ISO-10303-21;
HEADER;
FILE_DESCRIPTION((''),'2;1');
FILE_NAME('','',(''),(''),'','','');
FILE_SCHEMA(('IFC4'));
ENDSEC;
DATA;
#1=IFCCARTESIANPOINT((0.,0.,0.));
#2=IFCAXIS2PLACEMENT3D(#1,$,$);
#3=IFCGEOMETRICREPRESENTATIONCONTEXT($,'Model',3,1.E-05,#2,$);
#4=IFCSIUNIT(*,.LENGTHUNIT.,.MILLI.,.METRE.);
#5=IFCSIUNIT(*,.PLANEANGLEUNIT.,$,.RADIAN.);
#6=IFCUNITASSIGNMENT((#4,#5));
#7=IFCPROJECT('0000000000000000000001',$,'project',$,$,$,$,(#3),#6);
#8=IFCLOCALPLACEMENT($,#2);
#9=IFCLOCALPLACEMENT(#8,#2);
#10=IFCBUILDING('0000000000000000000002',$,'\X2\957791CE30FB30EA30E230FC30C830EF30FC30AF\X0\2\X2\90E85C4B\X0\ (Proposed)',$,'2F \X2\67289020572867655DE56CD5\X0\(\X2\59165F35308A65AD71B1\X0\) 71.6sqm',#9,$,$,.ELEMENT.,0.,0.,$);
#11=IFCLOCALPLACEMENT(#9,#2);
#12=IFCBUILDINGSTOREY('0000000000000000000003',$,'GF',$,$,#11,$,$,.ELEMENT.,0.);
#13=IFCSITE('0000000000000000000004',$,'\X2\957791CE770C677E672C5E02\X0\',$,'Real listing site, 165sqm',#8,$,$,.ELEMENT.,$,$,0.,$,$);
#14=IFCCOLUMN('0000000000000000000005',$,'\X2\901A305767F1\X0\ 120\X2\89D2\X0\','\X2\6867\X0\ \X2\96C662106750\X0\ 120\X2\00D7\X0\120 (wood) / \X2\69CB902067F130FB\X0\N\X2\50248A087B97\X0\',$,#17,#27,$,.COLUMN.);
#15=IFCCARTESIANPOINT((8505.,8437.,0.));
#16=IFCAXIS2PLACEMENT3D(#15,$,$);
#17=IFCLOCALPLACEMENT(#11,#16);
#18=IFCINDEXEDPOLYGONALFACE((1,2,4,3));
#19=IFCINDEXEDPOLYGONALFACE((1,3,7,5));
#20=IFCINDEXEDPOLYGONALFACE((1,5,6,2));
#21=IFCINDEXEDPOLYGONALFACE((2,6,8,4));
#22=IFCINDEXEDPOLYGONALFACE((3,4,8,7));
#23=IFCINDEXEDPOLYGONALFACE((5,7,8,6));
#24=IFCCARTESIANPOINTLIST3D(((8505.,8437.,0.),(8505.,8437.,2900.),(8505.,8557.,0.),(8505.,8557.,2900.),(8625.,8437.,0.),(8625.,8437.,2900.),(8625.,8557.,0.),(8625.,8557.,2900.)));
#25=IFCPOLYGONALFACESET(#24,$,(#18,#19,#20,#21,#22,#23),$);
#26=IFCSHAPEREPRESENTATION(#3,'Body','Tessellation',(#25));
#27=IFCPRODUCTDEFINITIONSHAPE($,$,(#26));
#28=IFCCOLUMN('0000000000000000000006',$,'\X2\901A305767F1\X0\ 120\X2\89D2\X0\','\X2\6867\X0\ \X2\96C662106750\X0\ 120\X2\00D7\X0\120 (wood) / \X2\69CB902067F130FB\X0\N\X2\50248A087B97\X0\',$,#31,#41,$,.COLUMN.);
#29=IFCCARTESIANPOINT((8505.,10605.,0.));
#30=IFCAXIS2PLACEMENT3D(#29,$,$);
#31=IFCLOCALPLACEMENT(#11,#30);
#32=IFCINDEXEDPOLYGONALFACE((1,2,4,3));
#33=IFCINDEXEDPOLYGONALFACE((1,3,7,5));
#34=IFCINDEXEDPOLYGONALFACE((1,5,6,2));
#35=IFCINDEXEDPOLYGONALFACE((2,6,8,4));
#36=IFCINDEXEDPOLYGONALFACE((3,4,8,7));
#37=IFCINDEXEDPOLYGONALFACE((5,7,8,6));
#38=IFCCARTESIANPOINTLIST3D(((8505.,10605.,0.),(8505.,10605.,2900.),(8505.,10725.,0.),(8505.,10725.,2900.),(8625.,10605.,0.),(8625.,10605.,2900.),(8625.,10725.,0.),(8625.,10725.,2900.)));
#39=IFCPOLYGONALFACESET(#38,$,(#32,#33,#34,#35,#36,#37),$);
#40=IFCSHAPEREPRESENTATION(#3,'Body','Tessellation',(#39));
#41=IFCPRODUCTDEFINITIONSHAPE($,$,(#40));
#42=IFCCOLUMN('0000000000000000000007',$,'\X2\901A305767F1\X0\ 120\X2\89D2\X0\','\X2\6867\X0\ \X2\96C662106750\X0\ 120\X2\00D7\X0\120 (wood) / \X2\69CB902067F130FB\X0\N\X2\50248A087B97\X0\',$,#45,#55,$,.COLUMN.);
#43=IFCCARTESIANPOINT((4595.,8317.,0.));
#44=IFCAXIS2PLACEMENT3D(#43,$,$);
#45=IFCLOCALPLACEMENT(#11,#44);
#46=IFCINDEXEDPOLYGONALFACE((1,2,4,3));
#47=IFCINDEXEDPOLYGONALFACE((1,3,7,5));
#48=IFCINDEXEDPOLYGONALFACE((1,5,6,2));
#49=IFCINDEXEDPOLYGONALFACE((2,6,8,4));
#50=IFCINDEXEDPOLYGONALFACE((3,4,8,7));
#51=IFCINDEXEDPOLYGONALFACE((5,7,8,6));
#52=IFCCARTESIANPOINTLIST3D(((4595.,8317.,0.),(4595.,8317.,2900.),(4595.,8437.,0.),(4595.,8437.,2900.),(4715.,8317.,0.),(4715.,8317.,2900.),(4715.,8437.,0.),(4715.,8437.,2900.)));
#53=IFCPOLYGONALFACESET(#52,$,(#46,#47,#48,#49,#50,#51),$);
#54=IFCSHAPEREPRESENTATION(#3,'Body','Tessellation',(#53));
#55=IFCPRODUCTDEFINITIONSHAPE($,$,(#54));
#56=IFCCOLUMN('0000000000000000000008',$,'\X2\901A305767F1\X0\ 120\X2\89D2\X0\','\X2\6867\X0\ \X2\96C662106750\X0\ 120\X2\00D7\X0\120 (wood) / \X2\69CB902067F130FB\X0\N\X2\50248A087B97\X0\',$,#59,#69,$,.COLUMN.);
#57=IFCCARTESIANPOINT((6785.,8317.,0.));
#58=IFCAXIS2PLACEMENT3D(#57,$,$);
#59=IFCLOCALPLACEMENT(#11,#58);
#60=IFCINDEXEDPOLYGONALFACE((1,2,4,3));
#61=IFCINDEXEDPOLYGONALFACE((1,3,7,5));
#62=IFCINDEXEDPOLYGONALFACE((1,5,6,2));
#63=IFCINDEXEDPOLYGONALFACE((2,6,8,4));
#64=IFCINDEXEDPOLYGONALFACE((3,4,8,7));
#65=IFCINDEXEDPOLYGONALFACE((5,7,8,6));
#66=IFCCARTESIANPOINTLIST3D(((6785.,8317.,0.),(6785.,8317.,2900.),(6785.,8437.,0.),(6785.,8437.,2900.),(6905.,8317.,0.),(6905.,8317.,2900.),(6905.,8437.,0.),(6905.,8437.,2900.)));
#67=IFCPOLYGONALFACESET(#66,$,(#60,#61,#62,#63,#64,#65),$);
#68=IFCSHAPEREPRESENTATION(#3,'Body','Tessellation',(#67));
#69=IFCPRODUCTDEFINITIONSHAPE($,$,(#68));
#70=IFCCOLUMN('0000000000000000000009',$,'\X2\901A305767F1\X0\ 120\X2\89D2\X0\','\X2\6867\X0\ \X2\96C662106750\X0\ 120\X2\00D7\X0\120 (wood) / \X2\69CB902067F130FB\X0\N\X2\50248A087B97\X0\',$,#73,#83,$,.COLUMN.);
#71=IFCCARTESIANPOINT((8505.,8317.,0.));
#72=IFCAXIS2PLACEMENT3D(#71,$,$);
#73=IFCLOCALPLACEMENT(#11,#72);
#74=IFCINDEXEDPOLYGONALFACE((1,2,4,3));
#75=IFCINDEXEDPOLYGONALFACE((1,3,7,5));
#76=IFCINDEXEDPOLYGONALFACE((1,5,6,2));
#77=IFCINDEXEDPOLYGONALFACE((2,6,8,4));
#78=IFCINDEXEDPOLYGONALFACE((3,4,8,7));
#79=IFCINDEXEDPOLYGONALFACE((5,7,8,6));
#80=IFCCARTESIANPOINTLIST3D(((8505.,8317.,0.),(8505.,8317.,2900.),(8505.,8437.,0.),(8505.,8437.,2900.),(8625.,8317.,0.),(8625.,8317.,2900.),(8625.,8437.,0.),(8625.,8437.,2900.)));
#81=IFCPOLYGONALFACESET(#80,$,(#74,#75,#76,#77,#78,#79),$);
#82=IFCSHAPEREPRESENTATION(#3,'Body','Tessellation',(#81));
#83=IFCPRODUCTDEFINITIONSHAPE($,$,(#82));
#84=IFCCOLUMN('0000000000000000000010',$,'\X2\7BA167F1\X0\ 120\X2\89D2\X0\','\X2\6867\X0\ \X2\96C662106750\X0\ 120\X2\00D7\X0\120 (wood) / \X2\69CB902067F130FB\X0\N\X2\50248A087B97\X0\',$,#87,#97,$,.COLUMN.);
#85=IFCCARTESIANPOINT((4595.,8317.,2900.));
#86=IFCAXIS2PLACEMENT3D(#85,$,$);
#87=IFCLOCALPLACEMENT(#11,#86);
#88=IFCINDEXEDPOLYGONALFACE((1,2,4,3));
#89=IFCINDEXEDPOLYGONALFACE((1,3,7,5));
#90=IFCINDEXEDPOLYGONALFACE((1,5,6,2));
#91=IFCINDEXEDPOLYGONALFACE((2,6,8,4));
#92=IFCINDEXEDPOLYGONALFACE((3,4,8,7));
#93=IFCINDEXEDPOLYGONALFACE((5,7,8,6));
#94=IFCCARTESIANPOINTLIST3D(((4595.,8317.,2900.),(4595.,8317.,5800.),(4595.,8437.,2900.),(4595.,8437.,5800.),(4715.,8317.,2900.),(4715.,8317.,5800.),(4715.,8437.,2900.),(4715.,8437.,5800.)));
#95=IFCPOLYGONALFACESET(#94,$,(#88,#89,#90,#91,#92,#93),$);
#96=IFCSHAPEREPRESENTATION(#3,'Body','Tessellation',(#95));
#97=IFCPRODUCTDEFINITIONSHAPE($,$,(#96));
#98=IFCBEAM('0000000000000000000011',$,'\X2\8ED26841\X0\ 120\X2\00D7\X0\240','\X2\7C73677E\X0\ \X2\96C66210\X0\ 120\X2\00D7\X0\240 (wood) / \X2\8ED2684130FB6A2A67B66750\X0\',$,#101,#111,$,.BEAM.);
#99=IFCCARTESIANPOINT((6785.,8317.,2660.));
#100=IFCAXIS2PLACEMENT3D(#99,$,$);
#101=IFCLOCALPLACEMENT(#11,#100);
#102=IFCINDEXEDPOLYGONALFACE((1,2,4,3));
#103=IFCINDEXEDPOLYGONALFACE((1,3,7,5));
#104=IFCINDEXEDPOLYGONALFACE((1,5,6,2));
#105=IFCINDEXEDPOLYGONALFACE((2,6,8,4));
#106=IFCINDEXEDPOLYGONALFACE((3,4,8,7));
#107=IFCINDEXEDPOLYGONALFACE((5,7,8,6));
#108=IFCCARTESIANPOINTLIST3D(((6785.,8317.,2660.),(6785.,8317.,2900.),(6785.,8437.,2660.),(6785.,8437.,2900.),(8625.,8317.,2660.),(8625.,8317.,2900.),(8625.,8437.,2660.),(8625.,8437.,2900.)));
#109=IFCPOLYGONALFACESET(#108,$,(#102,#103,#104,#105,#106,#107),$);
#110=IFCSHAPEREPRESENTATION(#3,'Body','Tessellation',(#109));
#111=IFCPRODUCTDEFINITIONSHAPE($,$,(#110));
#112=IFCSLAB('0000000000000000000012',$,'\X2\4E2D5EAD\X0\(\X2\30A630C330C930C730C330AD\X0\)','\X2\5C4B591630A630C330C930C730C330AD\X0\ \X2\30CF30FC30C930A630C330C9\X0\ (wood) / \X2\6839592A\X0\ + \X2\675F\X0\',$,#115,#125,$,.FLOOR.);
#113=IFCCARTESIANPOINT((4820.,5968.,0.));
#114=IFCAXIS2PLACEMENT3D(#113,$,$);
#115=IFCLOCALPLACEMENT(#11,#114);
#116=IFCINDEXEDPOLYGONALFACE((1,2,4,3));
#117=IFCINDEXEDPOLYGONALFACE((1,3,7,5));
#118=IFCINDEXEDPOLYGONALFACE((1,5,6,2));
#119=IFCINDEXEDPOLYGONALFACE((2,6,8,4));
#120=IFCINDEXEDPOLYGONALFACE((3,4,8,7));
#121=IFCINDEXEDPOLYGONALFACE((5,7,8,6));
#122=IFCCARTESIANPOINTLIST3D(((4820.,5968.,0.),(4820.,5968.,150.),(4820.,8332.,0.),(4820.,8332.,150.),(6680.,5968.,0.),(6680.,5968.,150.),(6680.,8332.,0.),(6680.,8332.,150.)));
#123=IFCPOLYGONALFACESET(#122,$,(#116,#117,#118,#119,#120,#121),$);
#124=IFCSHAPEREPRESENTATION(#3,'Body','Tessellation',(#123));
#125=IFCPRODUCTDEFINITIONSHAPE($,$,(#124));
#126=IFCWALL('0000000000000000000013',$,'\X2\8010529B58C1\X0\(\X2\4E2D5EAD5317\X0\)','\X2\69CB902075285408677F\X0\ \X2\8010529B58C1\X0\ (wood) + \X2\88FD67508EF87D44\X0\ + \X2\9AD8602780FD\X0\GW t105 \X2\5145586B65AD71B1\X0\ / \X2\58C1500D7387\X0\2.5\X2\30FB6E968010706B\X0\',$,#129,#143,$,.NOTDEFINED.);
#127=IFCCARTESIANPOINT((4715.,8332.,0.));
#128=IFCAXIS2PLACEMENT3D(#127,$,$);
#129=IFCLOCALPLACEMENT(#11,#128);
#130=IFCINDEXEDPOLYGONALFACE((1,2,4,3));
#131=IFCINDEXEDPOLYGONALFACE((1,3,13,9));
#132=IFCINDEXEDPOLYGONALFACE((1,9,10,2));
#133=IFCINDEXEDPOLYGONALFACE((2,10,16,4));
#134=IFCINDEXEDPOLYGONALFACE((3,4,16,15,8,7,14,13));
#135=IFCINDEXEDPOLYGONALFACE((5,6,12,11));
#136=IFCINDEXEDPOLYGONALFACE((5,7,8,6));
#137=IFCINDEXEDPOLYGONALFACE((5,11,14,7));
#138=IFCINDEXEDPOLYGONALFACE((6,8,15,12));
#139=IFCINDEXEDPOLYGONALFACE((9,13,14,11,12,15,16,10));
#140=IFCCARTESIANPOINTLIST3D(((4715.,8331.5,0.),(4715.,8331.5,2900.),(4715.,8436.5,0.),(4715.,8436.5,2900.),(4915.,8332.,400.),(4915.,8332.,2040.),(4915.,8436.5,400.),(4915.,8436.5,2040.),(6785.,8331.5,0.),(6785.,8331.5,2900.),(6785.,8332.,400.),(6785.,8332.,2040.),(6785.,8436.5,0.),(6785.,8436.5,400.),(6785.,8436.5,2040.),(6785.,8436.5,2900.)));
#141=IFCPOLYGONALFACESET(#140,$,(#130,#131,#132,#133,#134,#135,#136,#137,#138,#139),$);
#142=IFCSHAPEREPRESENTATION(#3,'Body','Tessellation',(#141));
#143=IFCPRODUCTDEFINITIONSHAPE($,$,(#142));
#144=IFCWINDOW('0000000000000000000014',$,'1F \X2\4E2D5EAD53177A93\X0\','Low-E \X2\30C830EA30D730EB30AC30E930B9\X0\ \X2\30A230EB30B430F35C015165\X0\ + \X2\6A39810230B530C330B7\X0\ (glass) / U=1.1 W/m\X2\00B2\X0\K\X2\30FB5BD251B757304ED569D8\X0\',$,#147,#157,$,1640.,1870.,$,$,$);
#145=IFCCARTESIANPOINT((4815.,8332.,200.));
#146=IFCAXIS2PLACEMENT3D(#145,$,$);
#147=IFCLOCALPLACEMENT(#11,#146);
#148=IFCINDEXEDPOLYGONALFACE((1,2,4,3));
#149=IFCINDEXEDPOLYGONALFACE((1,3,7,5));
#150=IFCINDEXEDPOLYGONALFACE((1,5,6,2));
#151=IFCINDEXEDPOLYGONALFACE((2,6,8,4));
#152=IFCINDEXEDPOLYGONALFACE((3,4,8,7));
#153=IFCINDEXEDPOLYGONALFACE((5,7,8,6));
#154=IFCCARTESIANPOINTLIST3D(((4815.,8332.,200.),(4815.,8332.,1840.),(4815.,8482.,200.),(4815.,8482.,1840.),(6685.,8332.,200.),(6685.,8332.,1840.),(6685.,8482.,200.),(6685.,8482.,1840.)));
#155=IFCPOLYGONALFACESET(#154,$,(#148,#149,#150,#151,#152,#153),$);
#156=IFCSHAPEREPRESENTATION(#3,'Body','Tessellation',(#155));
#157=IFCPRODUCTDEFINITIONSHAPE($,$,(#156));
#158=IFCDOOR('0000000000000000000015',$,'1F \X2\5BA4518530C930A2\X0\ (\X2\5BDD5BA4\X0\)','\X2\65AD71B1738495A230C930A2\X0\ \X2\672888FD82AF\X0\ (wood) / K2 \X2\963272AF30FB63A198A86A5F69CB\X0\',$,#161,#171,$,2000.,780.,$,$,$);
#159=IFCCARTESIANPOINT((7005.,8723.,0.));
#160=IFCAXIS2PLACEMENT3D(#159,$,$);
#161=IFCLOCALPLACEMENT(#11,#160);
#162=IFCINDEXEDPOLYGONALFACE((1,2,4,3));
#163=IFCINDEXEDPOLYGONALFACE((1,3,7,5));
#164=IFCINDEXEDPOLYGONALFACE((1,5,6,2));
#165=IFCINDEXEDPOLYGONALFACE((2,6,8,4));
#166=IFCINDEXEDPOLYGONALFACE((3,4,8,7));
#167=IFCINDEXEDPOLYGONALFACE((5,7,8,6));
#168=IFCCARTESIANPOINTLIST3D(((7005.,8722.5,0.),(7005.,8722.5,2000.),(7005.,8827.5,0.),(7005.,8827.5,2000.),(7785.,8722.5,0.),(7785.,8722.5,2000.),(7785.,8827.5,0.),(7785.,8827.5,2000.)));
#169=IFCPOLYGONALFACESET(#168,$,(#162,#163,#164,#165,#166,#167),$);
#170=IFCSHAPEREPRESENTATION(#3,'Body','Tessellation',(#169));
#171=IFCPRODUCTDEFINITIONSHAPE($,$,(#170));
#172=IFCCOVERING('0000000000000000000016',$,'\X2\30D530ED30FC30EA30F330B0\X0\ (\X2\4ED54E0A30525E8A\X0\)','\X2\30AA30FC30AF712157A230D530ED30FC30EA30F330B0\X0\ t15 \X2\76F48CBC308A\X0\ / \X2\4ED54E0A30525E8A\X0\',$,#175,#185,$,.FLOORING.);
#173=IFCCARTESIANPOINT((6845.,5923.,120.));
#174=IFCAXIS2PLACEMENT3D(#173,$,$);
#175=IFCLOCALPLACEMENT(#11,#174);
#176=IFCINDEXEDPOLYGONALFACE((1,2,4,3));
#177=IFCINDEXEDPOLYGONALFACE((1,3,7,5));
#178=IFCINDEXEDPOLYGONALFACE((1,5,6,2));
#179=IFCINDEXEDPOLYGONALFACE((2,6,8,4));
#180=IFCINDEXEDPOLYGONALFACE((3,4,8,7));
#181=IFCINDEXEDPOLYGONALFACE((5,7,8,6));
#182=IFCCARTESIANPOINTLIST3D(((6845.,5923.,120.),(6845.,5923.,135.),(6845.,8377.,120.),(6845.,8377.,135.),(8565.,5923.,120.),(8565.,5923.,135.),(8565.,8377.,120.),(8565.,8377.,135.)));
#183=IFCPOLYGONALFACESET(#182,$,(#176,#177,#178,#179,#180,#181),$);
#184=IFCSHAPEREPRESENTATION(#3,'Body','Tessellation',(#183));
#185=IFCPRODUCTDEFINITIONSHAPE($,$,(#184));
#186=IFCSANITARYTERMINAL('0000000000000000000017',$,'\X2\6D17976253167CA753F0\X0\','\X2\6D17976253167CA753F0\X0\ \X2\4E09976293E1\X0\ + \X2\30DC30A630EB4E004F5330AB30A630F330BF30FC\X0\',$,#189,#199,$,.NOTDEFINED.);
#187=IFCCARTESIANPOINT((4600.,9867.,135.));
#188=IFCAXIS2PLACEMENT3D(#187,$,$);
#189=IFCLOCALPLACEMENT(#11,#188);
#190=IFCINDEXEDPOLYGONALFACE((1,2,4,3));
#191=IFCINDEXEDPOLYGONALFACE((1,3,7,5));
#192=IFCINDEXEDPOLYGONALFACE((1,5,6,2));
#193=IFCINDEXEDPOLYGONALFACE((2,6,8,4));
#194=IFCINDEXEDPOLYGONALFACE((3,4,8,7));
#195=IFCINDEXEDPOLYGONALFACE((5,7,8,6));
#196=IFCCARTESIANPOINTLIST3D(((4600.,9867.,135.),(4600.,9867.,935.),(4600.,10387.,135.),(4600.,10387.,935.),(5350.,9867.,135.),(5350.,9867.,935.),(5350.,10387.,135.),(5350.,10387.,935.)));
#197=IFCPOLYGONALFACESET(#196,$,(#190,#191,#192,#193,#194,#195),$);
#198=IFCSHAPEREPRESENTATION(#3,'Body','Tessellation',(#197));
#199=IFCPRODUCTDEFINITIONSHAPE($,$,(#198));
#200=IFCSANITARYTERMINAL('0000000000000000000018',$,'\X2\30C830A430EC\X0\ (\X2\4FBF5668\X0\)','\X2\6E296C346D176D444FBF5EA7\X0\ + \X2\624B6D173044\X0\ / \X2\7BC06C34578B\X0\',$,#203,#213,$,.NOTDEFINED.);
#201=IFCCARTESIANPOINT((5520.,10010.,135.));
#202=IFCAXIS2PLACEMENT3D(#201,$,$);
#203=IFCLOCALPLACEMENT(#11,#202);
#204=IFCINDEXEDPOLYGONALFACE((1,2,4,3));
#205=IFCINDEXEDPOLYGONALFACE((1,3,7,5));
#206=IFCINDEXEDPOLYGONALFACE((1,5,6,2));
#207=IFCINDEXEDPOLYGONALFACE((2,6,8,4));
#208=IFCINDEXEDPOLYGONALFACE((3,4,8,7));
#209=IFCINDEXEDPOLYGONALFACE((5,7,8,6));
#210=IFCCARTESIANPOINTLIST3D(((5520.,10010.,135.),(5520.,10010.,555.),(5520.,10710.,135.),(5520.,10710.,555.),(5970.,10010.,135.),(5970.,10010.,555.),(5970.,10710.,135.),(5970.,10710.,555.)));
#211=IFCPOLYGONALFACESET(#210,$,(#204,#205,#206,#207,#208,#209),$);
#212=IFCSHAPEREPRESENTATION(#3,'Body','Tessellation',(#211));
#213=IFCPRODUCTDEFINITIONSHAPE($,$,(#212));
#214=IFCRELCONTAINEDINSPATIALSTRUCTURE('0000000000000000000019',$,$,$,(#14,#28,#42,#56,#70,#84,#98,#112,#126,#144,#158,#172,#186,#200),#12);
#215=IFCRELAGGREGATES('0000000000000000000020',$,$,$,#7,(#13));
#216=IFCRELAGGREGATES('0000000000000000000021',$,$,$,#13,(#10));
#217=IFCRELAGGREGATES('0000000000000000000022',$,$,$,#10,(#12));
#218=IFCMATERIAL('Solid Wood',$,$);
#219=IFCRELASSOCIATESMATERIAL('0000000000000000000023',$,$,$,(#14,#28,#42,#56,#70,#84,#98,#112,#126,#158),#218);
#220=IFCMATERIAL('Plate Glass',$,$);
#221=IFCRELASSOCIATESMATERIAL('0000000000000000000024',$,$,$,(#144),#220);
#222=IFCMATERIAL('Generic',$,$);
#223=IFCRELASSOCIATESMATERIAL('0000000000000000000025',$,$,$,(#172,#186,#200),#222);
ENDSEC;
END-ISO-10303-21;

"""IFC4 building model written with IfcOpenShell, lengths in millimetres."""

from ifc_helpers import new_model, si_unit, frame, frame_2d, origin, place, context, project, spatial, rectangle, extrude, material, element, fill, save


model = new_model("IFC4")

# Units and contexts
model_context = context("Model", 3, precision=1e-05, world=origin())
ifc_project = project(units=[si_unit("LENGTHUNIT", "METRE", prefix="MILLI"), si_unit("PLANEANGLEUNIT", "RADIAN")], contexts=[model_context])

# Site, building, storey
site_placement = place(None, origin())
site = spatial("IfcSite", under=ifc_project, at=site_placement, Name="長野県松本市", ObjectType="Real listing site, 165sqm", CompositionType="ELEMENT", RefElevation=0.0)
building_placement = place(site_placement, origin())
building = spatial("IfcBuilding", under=site, at=building_placement, Name="長野・リモートワーク2部屋 (Proposed)", ObjectType="2F 木造在来工法(外張り断熱) 71.6sqm", CompositionType="ELEMENT", ElevationOfRefHeight=0.0, ElevationOfTerrain=0.0)
storey_placement = place(building_placement, origin())
storey = spatial("IfcBuildingStorey", under=building, at=storey_placement, Name="GF", CompositionType="ELEMENT", Elevation=0.0)

# Columns
ifc_material_1 = material(Name="Solid Wood")
column_1_placement = place(storey_placement, frame((8505.0, 8437.0, 0.0)))
element("IfcColumn", 1, at=column_1_placement, inside=storey, material=ifc_material_1, Name="通し柱 120角", Description="桧 集成材 120×120 (wood) / 構造柱・N値計算", PredefinedType="COLUMN", context=model_context, shape_type="SweptSolid", body=[
    extrude(rectangle(XDim=120.0, YDim=120.0, at=frame_2d((60.0, 60.0))), frame((8505.0, 8437.0, 0.0)), (0.0, 0.0, 1.0), 2900.0),
])
column_2_placement = place(storey_placement, frame((8505.0, 10605.0, 0.0)))
element("IfcColumn", 2, at=column_2_placement, inside=storey, material=ifc_material_1, Name="通し柱 120角", Description="桧 集成材 120×120 (wood) / 構造柱・N値計算", PredefinedType="COLUMN", context=model_context, shape_type="SweptSolid", body=[
    extrude(rectangle(XDim=120.0, YDim=120.0, at=frame_2d((60.0, 60.0))), frame((8505.0, 10605.0, 0.0)), (0.0, 0.0, 1.0), 2900.0),
])
column_3_placement = place(storey_placement, frame((4595.0, 8317.0, 0.0)))
element("IfcColumn", 3, at=column_3_placement, inside=storey, material=ifc_material_1, Name="通し柱 120角", Description="桧 集成材 120×120 (wood) / 構造柱・N値計算", PredefinedType="COLUMN", context=model_context, shape_type="SweptSolid", body=[
    extrude(rectangle(XDim=120.0, YDim=120.0, at=frame_2d((60.0, 60.0))), frame((4595.0, 8317.0, 0.0)), (0.0, 0.0, 1.0), 2900.0),
])
column_4_placement = place(storey_placement, frame((6785.0, 8317.0, 0.0)))
element("IfcColumn", 4, at=column_4_placement, inside=storey, material=ifc_material_1, Name="通し柱 120角", Description="桧 集成材 120×120 (wood) / 構造柱・N値計算", PredefinedType="COLUMN", context=model_context, shape_type="SweptSolid", body=[
    extrude(rectangle(XDim=120.0, YDim=120.0, at=frame_2d((60.0, 60.0))), frame((6785.0, 8317.0, 0.0)), (0.0, 0.0, 1.0), 2900.0),
])
column_5_placement = place(storey_placement, frame((8505.0, 8317.0, 0.0)))
element("IfcColumn", 5, at=column_5_placement, inside=storey, material=ifc_material_1, Name="通し柱 120角", Description="桧 集成材 120×120 (wood) / 構造柱・N値計算", PredefinedType="COLUMN", context=model_context, shape_type="SweptSolid", body=[
    extrude(rectangle(XDim=120.0, YDim=120.0, at=frame_2d((60.0, 60.0))), frame((8505.0, 8317.0, 0.0)), (0.0, 0.0, 1.0), 2900.0),
])
column_6_placement = place(storey_placement, frame((4595.0, 8317.0, 2900.0)))
element("IfcColumn", 6, at=column_6_placement, inside=storey, material=ifc_material_1, Name="管柱 120角", Description="桧 集成材 120×120 (wood) / 構造柱・N値計算", PredefinedType="COLUMN", context=model_context, shape_type="SweptSolid", body=[
    extrude(rectangle(XDim=120.0, YDim=120.0, at=frame_2d((60.0, 60.0))), frame((4595.0, 8317.0, 2900.0)), (0.0, 0.0, 1.0), 2900.0),
])

# Beam
beam_1_placement = place(storey_placement, frame((6785.0, 8317.0, 2660.0)))
element("IfcBeam", 7, at=beam_1_placement, inside=storey, material=ifc_material_1, Name="軒桁 120×240", Description="米松 集成 120×240 (wood) / 軒桁・横架材", PredefinedType="BEAM", context=model_context, shape_type="SweptSolid", body=[
    extrude(rectangle(XDim=1840.0, YDim=120.0, at=frame_2d((920.0, 60.0))), frame((6785.0, 8317.0, 2660.0)), (0.0, 0.0, 1.0), 240.0),
])

# Slab
slab_placement = place(storey_placement, frame((4820.0, 5968.0, 0.0)))
element("IfcSlab", 8, at=slab_placement, inside=storey, material=ifc_material_1, Name="中庭(ウッドデッキ)", Description="屋外ウッドデッキ ハードウッド (wood) / 根太 + 束", PredefinedType="FLOOR", context=model_context, shape_type="SweptSolid", body=[
    extrude(rectangle(XDim=1860.0, YDim=2364.0, at=frame_2d((930.0, 1182.0))), frame((4820.0, 5968.0, 0.0)), (0.0, 0.0, 1.0), 150.0),
])

# Wall, opening, window
wall_1_placement = place(storey_placement, frame((4715.0, 8332.0, 0.0)))
wall_1 = element("IfcWall", 9, at=wall_1_placement, inside=storey, material=ifc_material_1, Name="耐力壁(中庭北)", Description="構造用合板 耐力壁 (wood) + 製材軸組 + 高性能GW t105 充填断熱 / 壁倍率2.5・準耐火", PredefinedType="NOTDEFINED", context=model_context, shape_type="SweptSolid", body=[
    extrude(rectangle(XDim=2070.0, YDim=105.0, at=frame_2d((1035.0, 52.0))), frame((4715.0, 8332.0, 0.0)), (0.0, 0.0, 1.0), 2900.0),
])
opening_placement = place(storey_placement, frame((4815.0, 8332.0, 200.0)))
opening = element("IfcOpeningElement", 10, at=opening_placement, cuts=wall_1, PredefinedType="NOTDEFINED", context=model_context, shape_type="SweptSolid", body=[
    extrude(rectangle(XDim=1870.0, YDim=150.0, at=frame_2d((935.0, 75.0))), frame((4815.0, 8332.0, 200.0)), (0.0, 0.0, 1.0), 1640.0),
])
ifc_material_2 = material(Name="Plate Glass")
window_placement = place(storey_placement, frame((4815.0, 8332.0, 200.0)))
window = element("IfcWindow", 11, at=window_placement, inside=storey, material=ifc_material_2, Name="1F 中庭北窓", Description="Low-E トリプルガラス アルゴン封入 + 樹脂サッシ (glass) / U=1.1 W/m²K・寒冷地仕様", OverallHeight=1640.0, OverallWidth=1870.0, context=model_context, shape_type="SweptSolid", body=[
    extrude(rectangle(XDim=1870.0, YDim=150.0, at=frame_2d((935.0, 75.0))), frame((4815.0, 8332.0, 200.0)), (0.0, 0.0, 1.0), 1640.0),
])
fill(opening, window)

# Door
door_placement = place(storey_placement, frame((7005.0, 8723.0, 0.0)))
element("IfcDoor", 12, at=door_placement, inside=storey, material=ifc_material_1, Name="1F 室内ドア (寝室)", Description="断熱玄関ドア 木製芯 (wood) / K2 防犯・採風機構", OverallHeight=2000.0, OverallWidth=780.0, context=model_context, shape_type="SweptSolid", body=[
    extrude(rectangle(XDim=780.0, YDim=105.0, at=frame_2d((390.0, 52.0))), frame((7005.0, 8723.0, 0.0)), (0.0, 0.0, 1.0), 2000.0),
])

# Covering
ifc_material_3 = material(Name="Generic")
covering_placement = place(storey_placement, frame((6845.0, 5923.0, 120.0)))
element("IfcCovering", 13, at=covering_placement, inside=storey, material=ifc_material_3, Name="フローリング (仕上げ床)", Description="オーク無垢フローリング t15 直貼り / 仕上げ床", PredefinedType="FLOORING", context=model_context, shape_type="SweptSolid", body=[
    extrude(rectangle(XDim=1720.0, YDim=2454.0, at=frame_2d((860.0, 1227.0))), frame((6845.0, 5923.0, 120.0)), (0.0, 0.0, 1.0), 15.0),
])

# Sanitary terminals
sanitary_terminal_1_placement = place(storey_placement, frame((4600.0, 9867.0, 135.0)))
element("IfcSanitaryTerminal", 14, at=sanitary_terminal_1_placement, inside=storey, material=ifc_material_3, Name="洗面化粧台", Description="洗面化粧台 三面鏡 + ボウル一体カウンター", PredefinedType="NOTDEFINED", context=model_context, shape_type="SweptSolid", body=[
    extrude(rectangle(XDim=750.0, YDim=520.0, at=frame_2d((375.0, 260.0))), frame((4600.0, 9867.0, 135.0)), (0.0, 0.0, 1.0), 800.0),
])
sanitary_terminal_2_placement = place(storey_placement, frame((5520.0, 10010.0, 135.0)))
element("IfcSanitaryTerminal", 15, at=sanitary_terminal_2_placement, inside=storey, material=ifc_material_3, Name="トイレ (便器)", Description="温水洗浄便座 + 手洗い / 節水型", PredefinedType="NOTDEFINED", context=model_context, shape_type="SweptSolid", body=[
    extrude(rectangle(XDim=450.0, YDim=700.0, at=frame_2d((225.0, 350.0))), frame((5520.0, 10010.0, 135.0)), (0.0, 0.0, 1.0), 420.0),
])

save(model, "model.ifc")
